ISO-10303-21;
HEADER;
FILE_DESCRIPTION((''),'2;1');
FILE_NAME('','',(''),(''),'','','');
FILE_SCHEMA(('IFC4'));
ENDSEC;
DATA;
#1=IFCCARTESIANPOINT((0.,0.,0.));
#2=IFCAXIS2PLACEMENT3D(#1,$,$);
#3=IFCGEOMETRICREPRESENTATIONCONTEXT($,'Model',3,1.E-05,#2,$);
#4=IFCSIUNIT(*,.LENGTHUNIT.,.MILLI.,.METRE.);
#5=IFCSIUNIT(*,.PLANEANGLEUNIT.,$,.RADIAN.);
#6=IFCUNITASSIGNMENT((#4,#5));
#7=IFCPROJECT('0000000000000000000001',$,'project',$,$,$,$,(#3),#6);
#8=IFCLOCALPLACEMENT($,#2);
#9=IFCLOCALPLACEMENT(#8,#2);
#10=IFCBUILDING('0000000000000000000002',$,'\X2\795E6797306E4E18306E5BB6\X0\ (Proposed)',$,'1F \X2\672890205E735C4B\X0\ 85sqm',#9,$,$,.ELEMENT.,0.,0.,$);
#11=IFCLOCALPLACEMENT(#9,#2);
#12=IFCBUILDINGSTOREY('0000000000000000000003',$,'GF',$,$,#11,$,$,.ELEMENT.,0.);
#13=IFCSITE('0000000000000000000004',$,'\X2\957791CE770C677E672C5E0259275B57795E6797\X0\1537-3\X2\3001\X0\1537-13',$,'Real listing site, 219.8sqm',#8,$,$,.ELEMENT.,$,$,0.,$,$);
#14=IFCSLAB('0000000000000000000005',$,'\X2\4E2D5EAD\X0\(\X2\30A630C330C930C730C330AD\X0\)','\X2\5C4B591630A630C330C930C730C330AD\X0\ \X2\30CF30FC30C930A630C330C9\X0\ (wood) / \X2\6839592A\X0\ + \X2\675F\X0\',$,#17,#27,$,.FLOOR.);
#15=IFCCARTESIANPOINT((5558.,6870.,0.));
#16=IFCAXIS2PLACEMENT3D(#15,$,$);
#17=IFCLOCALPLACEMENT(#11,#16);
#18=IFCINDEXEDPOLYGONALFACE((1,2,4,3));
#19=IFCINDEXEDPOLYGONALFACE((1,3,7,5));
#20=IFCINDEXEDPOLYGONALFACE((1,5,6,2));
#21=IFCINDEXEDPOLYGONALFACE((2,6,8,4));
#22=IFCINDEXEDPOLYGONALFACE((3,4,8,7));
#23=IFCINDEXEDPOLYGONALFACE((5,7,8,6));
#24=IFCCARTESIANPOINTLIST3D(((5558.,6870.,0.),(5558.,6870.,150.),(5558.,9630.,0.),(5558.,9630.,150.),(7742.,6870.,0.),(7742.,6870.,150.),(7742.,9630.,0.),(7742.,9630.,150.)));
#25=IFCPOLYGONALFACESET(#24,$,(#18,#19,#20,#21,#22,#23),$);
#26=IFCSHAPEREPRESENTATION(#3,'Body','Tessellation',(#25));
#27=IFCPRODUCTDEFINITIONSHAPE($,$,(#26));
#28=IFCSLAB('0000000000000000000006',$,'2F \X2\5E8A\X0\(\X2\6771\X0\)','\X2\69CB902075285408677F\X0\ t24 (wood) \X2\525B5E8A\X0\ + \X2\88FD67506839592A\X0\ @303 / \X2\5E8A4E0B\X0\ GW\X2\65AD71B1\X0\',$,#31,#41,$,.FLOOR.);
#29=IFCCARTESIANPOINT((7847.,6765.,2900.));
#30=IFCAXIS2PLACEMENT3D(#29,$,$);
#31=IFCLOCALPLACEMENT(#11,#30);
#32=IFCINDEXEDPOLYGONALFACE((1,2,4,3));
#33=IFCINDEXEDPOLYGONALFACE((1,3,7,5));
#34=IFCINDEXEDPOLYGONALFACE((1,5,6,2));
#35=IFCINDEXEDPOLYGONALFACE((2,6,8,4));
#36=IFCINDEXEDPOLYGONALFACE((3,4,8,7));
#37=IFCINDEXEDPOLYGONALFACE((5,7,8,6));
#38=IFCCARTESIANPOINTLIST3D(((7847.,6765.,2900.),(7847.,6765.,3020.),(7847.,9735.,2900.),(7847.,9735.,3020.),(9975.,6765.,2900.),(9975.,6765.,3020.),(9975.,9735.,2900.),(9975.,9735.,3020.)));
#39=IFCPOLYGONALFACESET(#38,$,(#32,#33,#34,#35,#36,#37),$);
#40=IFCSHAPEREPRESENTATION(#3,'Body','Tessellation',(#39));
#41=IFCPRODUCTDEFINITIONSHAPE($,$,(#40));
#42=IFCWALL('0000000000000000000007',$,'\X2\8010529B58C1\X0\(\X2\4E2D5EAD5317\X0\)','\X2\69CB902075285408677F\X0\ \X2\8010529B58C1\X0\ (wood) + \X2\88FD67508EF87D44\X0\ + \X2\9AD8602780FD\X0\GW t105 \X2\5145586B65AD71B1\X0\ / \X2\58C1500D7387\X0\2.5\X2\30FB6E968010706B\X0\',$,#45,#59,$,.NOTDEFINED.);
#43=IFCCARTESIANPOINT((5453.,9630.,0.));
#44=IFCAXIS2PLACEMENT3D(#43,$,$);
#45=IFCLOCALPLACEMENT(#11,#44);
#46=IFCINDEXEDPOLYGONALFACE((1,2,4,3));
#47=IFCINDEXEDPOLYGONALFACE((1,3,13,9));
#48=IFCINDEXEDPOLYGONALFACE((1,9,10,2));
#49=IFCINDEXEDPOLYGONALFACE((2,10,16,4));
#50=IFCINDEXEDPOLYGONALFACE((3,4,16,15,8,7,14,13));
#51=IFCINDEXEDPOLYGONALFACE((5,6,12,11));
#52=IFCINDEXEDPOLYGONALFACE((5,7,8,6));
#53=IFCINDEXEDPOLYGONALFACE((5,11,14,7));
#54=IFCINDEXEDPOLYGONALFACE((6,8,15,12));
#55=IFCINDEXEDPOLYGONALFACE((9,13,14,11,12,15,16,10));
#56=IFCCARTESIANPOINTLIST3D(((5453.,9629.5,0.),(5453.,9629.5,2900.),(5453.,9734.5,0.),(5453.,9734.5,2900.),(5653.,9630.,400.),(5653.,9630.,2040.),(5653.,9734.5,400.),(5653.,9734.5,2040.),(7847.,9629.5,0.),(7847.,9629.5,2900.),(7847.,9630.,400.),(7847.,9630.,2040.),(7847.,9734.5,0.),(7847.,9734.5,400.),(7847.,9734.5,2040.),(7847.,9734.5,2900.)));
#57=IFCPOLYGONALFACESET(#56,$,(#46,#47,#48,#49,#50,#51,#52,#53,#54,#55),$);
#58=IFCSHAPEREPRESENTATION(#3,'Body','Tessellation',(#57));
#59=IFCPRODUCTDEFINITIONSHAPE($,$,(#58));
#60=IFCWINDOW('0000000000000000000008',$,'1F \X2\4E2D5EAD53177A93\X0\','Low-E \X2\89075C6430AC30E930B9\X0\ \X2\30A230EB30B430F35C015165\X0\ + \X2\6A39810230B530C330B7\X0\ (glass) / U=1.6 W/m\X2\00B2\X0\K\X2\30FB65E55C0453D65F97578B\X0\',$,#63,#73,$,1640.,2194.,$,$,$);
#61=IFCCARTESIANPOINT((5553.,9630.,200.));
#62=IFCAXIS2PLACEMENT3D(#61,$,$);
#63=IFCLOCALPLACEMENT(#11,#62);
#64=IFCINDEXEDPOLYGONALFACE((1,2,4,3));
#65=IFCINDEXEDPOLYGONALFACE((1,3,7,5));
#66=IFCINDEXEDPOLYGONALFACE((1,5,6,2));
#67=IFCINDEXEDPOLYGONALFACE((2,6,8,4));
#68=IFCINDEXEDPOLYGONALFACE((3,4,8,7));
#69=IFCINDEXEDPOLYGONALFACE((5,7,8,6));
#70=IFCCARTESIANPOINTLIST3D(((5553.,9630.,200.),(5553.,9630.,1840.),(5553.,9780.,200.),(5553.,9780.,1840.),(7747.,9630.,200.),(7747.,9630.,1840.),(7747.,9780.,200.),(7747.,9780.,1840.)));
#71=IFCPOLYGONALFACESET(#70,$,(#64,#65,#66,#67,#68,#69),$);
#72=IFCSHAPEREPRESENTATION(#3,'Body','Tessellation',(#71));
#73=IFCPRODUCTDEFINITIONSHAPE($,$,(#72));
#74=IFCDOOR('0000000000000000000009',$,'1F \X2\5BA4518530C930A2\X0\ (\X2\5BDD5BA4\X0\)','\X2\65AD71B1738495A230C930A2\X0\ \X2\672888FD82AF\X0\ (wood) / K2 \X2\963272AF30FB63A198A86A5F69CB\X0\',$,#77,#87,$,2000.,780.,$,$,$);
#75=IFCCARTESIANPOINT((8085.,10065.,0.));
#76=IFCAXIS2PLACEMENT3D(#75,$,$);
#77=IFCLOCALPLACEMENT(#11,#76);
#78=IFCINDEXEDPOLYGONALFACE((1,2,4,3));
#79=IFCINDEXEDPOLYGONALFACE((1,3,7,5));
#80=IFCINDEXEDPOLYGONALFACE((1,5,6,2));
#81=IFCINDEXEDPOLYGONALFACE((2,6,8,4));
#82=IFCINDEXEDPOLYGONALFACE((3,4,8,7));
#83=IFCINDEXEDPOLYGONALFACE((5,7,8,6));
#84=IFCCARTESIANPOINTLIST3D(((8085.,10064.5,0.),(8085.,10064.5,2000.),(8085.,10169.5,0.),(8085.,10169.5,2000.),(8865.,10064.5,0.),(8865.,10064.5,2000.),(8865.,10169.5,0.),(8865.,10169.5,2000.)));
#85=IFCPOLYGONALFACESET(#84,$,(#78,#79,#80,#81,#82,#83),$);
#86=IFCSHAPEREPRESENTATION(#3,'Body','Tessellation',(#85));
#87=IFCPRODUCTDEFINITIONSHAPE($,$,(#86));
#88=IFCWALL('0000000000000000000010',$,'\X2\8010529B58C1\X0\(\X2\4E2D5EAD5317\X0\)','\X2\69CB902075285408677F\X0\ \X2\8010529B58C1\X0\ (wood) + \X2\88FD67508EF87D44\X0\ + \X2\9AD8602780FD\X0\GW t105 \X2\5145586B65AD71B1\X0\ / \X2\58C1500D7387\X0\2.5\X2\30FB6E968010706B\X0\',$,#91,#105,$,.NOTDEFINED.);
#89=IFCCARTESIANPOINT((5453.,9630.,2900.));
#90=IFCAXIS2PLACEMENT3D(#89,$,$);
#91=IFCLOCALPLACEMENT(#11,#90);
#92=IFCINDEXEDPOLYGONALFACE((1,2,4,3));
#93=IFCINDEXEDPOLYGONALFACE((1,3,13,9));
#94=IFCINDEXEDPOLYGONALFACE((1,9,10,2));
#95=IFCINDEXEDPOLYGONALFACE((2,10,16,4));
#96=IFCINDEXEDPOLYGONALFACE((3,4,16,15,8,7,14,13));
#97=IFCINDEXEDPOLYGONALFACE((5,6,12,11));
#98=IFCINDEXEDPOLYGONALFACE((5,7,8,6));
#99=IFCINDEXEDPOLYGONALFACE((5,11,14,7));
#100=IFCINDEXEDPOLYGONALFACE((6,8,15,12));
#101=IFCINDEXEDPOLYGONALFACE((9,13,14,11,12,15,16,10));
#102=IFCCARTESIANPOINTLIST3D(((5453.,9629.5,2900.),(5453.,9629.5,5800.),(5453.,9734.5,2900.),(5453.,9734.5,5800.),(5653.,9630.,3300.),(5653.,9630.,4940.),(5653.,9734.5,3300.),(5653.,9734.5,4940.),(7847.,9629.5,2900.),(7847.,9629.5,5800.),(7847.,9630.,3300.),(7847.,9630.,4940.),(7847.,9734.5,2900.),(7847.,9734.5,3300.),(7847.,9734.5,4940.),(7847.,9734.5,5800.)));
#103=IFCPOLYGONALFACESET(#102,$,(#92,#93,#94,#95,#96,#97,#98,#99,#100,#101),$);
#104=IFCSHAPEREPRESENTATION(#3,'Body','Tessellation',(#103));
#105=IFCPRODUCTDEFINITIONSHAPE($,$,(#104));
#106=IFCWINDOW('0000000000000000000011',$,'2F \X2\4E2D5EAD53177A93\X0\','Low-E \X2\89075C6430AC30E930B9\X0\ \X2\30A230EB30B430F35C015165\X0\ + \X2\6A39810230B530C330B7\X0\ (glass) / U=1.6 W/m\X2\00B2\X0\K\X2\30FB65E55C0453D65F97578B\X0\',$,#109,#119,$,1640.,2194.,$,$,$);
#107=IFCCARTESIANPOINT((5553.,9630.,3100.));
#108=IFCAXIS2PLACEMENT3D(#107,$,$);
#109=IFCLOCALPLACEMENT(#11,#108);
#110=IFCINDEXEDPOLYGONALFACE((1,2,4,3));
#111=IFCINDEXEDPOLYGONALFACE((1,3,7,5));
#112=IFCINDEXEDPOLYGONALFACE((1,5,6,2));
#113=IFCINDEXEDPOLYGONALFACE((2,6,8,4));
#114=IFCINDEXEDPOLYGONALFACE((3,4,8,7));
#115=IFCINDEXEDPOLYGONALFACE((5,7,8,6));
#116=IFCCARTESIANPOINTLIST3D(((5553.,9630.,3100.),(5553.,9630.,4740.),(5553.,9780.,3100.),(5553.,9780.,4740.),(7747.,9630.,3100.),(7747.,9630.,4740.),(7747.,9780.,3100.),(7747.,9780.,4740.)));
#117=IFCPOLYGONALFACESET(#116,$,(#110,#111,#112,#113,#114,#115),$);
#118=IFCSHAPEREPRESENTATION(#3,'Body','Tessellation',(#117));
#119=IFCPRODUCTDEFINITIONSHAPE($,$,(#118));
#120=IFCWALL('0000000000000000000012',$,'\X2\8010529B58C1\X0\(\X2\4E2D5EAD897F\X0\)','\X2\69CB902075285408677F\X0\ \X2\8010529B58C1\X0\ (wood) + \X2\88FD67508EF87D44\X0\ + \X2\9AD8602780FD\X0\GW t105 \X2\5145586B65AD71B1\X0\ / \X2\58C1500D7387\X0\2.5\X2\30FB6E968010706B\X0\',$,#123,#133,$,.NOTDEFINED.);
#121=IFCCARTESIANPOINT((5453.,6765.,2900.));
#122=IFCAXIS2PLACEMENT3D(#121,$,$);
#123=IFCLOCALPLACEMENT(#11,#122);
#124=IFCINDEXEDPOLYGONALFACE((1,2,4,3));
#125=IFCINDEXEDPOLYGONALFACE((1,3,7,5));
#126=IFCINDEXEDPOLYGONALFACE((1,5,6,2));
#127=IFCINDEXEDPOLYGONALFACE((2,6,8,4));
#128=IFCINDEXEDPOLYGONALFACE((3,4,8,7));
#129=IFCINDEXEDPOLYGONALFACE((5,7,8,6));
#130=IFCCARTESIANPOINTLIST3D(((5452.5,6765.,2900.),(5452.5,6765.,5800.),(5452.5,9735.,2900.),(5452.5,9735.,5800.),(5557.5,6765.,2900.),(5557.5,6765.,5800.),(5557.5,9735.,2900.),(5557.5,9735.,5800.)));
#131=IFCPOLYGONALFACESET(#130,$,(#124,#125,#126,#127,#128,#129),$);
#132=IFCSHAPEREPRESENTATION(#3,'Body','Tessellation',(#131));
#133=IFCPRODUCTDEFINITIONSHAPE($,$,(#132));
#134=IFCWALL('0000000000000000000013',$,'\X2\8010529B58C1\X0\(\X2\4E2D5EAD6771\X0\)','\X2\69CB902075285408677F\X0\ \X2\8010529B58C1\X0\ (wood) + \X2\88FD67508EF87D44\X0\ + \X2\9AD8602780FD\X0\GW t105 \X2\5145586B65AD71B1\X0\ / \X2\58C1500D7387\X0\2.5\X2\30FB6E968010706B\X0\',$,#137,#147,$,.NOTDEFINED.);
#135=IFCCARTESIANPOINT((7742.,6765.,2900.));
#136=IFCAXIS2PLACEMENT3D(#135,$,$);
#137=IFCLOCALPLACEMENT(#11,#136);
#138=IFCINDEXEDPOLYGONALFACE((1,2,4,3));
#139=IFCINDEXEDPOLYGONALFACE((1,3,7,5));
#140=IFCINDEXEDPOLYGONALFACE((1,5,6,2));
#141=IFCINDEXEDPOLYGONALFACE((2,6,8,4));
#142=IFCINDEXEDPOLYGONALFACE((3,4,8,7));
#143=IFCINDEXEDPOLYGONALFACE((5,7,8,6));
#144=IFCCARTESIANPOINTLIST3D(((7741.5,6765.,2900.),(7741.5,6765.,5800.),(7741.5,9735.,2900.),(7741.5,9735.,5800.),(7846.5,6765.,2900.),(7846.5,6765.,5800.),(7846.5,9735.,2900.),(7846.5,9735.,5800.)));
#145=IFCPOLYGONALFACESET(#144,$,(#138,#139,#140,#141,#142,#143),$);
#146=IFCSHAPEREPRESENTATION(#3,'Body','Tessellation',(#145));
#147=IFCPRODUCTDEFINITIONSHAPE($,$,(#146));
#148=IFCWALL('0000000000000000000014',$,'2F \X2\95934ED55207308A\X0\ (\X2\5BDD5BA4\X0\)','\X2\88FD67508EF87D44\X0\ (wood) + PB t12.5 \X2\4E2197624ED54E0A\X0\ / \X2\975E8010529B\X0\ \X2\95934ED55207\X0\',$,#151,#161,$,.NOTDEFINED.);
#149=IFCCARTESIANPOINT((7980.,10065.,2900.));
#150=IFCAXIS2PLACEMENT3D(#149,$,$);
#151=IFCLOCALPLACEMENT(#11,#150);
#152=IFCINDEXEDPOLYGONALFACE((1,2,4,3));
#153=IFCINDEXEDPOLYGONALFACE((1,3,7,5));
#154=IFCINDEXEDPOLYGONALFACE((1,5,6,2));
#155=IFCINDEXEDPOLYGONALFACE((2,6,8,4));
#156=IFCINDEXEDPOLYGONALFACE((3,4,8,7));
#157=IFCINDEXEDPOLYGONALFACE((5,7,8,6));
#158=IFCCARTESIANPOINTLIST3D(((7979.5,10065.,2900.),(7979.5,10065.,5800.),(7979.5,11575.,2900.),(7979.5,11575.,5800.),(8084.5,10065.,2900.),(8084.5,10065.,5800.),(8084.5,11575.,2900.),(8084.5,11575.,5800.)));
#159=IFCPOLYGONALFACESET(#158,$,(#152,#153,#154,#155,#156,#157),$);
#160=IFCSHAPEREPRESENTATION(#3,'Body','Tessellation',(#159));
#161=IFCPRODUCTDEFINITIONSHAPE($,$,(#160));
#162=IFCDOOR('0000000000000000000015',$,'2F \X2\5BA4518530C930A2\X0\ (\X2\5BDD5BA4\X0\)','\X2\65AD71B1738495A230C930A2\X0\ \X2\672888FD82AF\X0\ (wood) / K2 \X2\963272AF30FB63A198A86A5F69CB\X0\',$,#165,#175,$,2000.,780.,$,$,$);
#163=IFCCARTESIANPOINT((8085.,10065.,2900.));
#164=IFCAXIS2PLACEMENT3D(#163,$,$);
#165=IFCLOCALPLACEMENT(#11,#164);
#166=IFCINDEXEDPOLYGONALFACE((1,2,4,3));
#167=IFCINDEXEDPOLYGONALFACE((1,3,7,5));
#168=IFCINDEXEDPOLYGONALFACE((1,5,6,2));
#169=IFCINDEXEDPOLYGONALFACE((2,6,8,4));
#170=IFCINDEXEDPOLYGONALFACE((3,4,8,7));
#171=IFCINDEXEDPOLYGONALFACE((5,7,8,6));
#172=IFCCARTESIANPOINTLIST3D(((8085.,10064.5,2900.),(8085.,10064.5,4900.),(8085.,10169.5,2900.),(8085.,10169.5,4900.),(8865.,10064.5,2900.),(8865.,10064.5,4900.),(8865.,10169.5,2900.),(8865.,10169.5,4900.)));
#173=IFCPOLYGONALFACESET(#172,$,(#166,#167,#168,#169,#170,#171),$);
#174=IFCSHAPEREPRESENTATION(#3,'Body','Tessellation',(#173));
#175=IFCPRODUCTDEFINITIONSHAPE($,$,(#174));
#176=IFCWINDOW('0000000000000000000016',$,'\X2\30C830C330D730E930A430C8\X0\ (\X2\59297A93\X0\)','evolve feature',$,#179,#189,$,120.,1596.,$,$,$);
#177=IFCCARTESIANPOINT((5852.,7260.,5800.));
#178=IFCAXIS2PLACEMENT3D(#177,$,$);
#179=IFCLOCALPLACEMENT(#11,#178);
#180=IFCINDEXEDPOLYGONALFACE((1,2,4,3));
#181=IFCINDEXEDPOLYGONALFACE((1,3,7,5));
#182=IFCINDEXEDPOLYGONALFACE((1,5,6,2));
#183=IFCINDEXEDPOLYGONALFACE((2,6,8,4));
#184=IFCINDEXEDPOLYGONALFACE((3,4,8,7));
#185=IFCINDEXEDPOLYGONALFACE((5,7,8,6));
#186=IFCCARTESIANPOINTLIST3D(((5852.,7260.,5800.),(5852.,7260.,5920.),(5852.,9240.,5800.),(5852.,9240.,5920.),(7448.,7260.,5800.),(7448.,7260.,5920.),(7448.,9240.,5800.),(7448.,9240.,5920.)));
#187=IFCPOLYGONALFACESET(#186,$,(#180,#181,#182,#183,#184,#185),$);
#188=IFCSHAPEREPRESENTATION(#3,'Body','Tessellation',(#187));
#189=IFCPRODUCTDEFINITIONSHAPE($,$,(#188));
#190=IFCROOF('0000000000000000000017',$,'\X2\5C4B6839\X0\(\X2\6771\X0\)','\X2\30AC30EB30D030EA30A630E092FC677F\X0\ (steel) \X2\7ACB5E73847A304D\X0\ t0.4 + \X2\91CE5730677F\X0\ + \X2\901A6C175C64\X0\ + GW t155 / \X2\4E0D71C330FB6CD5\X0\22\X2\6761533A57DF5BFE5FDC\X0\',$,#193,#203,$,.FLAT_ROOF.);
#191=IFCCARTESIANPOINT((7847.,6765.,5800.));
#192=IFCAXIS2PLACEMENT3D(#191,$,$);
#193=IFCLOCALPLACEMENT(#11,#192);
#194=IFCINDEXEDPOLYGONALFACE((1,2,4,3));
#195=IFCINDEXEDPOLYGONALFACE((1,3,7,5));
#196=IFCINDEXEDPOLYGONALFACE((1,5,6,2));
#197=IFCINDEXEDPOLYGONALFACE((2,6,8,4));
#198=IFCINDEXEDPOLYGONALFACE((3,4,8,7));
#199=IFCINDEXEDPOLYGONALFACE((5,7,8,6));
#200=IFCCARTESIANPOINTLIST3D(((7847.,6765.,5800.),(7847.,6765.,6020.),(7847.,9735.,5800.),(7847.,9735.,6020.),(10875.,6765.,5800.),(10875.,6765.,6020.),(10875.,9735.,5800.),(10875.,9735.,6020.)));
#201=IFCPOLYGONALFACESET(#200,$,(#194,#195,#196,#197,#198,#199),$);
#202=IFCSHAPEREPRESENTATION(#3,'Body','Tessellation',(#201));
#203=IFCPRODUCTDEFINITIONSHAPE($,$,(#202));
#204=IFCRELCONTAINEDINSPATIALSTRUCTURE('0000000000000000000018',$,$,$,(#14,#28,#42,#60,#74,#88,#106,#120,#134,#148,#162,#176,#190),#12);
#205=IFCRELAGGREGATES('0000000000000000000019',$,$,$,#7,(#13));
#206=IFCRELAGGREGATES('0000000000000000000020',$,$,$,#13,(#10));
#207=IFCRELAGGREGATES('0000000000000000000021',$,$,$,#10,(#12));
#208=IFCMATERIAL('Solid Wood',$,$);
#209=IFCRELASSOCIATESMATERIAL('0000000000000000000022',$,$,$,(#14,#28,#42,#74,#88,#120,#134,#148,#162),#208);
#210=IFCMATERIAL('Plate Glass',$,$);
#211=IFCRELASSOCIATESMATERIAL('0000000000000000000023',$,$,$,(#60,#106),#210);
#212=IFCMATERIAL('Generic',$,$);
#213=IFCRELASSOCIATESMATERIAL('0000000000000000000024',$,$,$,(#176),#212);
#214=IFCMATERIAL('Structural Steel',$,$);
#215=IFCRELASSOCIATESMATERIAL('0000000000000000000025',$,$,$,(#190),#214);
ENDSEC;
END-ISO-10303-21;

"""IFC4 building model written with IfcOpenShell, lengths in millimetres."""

from ifc_helpers import new_model, si_unit, frame, frame_2d, origin, place, context, project, spatial, rectangle, extrude, material, element, fill, save


model = new_model("IFC4")

# Units and contexts
model_context = context("Model", 3, precision=1e-05, world=origin())
ifc_project = project(units=[si_unit("LENGTHUNIT", "METRE", prefix="MILLI"), si_unit("PLANEANGLEUNIT", "RADIAN")], contexts=[model_context])

# Site, building, storey
site_placement = place(None, origin())
site = spatial("IfcSite", under=ifc_project, at=site_placement, Name="長野県松本市大字神林1537-3、1537-13", ObjectType="Real listing site, 219.8sqm", CompositionType="ELEMENT", RefElevation=0.0)
building_placement = place(site_placement, origin())
building = spatial("IfcBuilding", under=site, at=building_placement, Name="神林の丘の家 (Proposed)", ObjectType="1F 木造平屋 85sqm", CompositionType="ELEMENT", ElevationOfRefHeight=0.0, ElevationOfTerrain=0.0)
storey_placement = place(building_placement, origin())
storey = spatial("IfcBuildingStorey", under=building, at=storey_placement, Name="GF", CompositionType="ELEMENT", Elevation=0.0)

# Slabs
ifc_material_1 = material(Name="Solid Wood")
slab_1_placement = place(storey_placement, frame((5558.0, 6870.0, 0.0)))
element("IfcSlab", 1, at=slab_1_placement, inside=storey, material=ifc_material_1, Name="中庭(ウッドデッキ)", Description="屋外ウッドデッキ ハードウッド (wood) / 根太 + 束", PredefinedType="FLOOR", context=model_context, shape_type="SweptSolid", body=[
    extrude(rectangle(XDim=2184.0, YDim=2760.0, at=frame_2d((1092.0, 1380.0))), frame((5558.0, 6870.0, 0.0)), (0.0, 0.0, 1.0), 150.0),
])
slab_2_placement = place(storey_placement, frame((7847.0, 6765.0, 2900.0)))
element("IfcSlab", 2, at=slab_2_placement, inside=storey, material=ifc_material_1, Name="2F 床(東)", Description="構造用合板 t24 (wood) 剛床 + 製材根太 @303 / 床下 GW断熱", PredefinedType="FLOOR", context=model_context, shape_type="SweptSolid", body=[
    extrude(rectangle(XDim=2128.0, YDim=2970.0, at=frame_2d((1064.0, 1485.0))), frame((7847.0, 6765.0, 2900.0)), (0.0, 0.0, 1.0), 120.0),
])

# Wall, opening, window
wall_1_placement = place(storey_placement, frame((5453.0, 9630.0, 0.0)))
wall_1 = element("IfcWall", 3, at=wall_1_placement, inside=storey, material=ifc_material_1, Name="耐力壁(中庭北)", Description="構造用合板 耐力壁 (wood) + 製材軸組 + 高性能GW t105 充填断熱 / 壁倍率2.5・準耐火", PredefinedType="NOTDEFINED", context=model_context, shape_type="SweptSolid", body=[
    extrude(rectangle(XDim=2394.0, YDim=105.0, at=frame_2d((1197.0, 52.0))), frame((5453.0, 9630.0, 0.0)), (0.0, 0.0, 1.0), 2900.0),
])
opening_1_placement = place(storey_placement, frame((5553.0, 9630.0, 200.0)))
opening_1 = element("IfcOpeningElement", 4, at=opening_1_placement, cuts=wall_1, PredefinedType="NOTDEFINED", context=model_context, shape_type="SweptSolid", body=[
    extrude(rectangle(XDim=2194.0, YDim=150.0, at=frame_2d((1097.0, 75.0))), frame((5553.0, 9630.0, 200.0)), (0.0, 0.0, 1.0), 1640.0),
])
ifc_material_2 = material(Name="Plate Glass")
window_1_placement = place(storey_placement, frame((5553.0, 9630.0, 200.0)))
window_1 = element("IfcWindow", 5, at=window_1_placement, inside=storey, material=ifc_material_2, Name="1F 中庭北窓", Description="Low-E 複層ガラス アルゴン封入 + 樹脂サッシ (glass) / U=1.6 W/m²K・日射取得型", OverallHeight=1640.0, OverallWidth=2194.0, context=model_context, shape_type="SweptSolid", body=[
    extrude(rectangle(XDim=2194.0, YDim=150.0, at=frame_2d((1097.0, 75.0))), frame((5553.0, 9630.0, 200.0)), (0.0, 0.0, 1.0), 1640.0),
])
fill(opening_1, window_1)

# Door
door_1_placement = place(storey_placement, frame((8085.0, 10065.0, 0.0)))
element("IfcDoor", 6, at=door_1_placement, inside=storey, material=ifc_material_1, Name="1F 室内ドア (寝室)", Description="断熱玄関ドア 木製芯 (wood) / K2 防犯・採風機構", OverallHeight=2000.0, OverallWidth=780.0, context=model_context, shape_type="SweptSolid", body=[
    extrude(rectangle(XDim=780.0, YDim=105.0, at=frame_2d((390.0, 52.0))), frame((8085.0, 10065.0, 0.0)), (0.0, 0.0, 1.0), 2000.0),
])

# Wall, opening, window
wall_2_placement = place(storey_placement, frame((5453.0, 9630.0, 2900.0)))
wall_2 = element("IfcWall", 7, at=wall_2_placement, inside=storey, material=ifc_material_1, Name="耐力壁(中庭北)", Description="構造用合板 耐力壁 (wood) + 製材軸組 + 高性能GW t105 充填断熱 / 壁倍率2.5・準耐火", PredefinedType="NOTDEFINED", context=model_context, shape_type="SweptSolid", body=[
    extrude(rectangle(XDim=2394.0, YDim=105.0, at=frame_2d((1197.0, 52.0))), frame((5453.0, 9630.0, 2900.0)), (0.0, 0.0, 1.0), 2900.0),
])
opening_2_placement = place(storey_placement, frame((5553.0, 9630.0, 3100.0)))
opening_2 = element("IfcOpeningElement", 8, at=opening_2_placement, cuts=wall_2, PredefinedType="NOTDEFINED", context=model_context, shape_type="SweptSolid", body=[
    extrude(rectangle(XDim=2194.0, YDim=150.0, at=frame_2d((1097.0, 75.0))), frame((5553.0, 9630.0, 3100.0)), (0.0, 0.0, 1.0), 1640.0),
])
window_2_placement = place(storey_placement, frame((5553.0, 9630.0, 3100.0)))
window_2 = element("IfcWindow", 9, at=window_2_placement, inside=storey, material=ifc_material_2, Name="2F 中庭北窓", Description="Low-E 複層ガラス アルゴン封入 + 樹脂サッシ (glass) / U=1.6 W/m²K・日射取得型", OverallHeight=1640.0, OverallWidth=2194.0, context=model_context, shape_type="SweptSolid", body=[
    extrude(rectangle(XDim=2194.0, YDim=150.0, at=frame_2d((1097.0, 75.0))), frame((5553.0, 9630.0, 3100.0)), (0.0, 0.0, 1.0), 1640.0),
])
fill(opening_2, window_2)

# Walls
wall_3_placement = place(storey_placement, frame((5453.0, 6765.0, 2900.0)))
element("IfcWall", 10, at=wall_3_placement, inside=storey, material=ifc_material_1, Name="耐力壁(中庭西)", Description="構造用合板 耐力壁 (wood) + 製材軸組 + 高性能GW t105 充填断熱 / 壁倍率2.5・準耐火", PredefinedType="NOTDEFINED", context=model_context, shape_type="SweptSolid", body=[
    extrude(rectangle(XDim=105.0, YDim=2970.0, at=frame_2d((52.0, 1485.0))), frame((5453.0, 6765.0, 2900.0)), (0.0, 0.0, 1.0), 2900.0),
])
wall_4_placement = place(storey_placement, frame((7742.0, 6765.0, 2900.0)))
element("IfcWall", 11, at=wall_4_placement, inside=storey, material=ifc_material_1, Name="耐力壁(中庭東)", Description="構造用合板 耐力壁 (wood) + 製材軸組 + 高性能GW t105 充填断熱 / 壁倍率2.5・準耐火", PredefinedType="NOTDEFINED", context=model_context, shape_type="SweptSolid", body=[
    extrude(rectangle(XDim=105.0, YDim=2970.0, at=frame_2d((52.0, 1485.0))), frame((7742.0, 6765.0, 2900.0)), (0.0, 0.0, 1.0), 2900.0),
])
wall_5_placement = place(storey_placement, frame((7980.0, 10065.0, 2900.0)))
element("IfcWall", 12, at=wall_5_placement, inside=storey, material=ifc_material_1, Name="2F 間仕切り (寝室)", Description="製材軸組 (wood) + PB t12.5 両面仕上 / 非耐力 間仕切", PredefinedType="NOTDEFINED", context=model_context, shape_type="SweptSolid", body=[
    extrude(rectangle(XDim=105.0, YDim=1510.0, at=frame_2d((52.0, 755.0))), frame((7980.0, 10065.0, 2900.0)), (0.0, 0.0, 1.0), 2900.0),
])

# Door
door_2_placement = place(storey_placement, frame((8085.0, 10065.0, 2900.0)))
element("IfcDoor", 13, at=door_2_placement, inside=storey, material=ifc_material_1, Name="2F 室内ドア (寝室)", Description="断熱玄関ドア 木製芯 (wood) / K2 防犯・採風機構", OverallHeight=2000.0, OverallWidth=780.0, context=model_context, shape_type="SweptSolid", body=[
    extrude(rectangle(XDim=780.0, YDim=105.0, at=frame_2d((390.0, 52.0))), frame((8085.0, 10065.0, 2900.0)), (0.0, 0.0, 1.0), 2000.0),
])

# Window
ifc_material_3 = material(Name="Generic")
window_3_placement = place(storey_placement, frame((5852.0, 7260.0, 5800.0)))
element("IfcWindow", 14, at=window_3_placement, inside=storey, material=ifc_material_3, Name="トップライト (天窓)", Description="evolve feature", OverallHeight=120.0, OverallWidth=1596.0, context=model_context, shape_type="SweptSolid", body=[
    extrude(rectangle(XDim=1596.0, YDim=1980.0, at=frame_2d((798.0, 990.0))), frame((5852.0, 7260.0, 5800.0)), (0.0, 0.0, 1.0), 120.0),
])

# Roof
ifc_material_4 = material(Name="Structural Steel")
roof_placement = place(storey_placement, frame((7847.0, 6765.0, 5800.0)))
element("IfcRoof", 15, at=roof_placement, inside=storey, material=ifc_material_4, Name="屋根(東)", Description="ガルバリウム鋼板 (steel) 立平葺き t0.4 + 野地板 + 通気層 + GW t155 / 不燃・法22条区域対応", PredefinedType="FLAT_ROOF", context=model_context, shape_type="SweptSolid", body=[
    extrude(rectangle(XDim=3028.0, YDim=2970.0, at=frame_2d((1514.0, 1485.0))), frame((7847.0, 6765.0, 5800.0)), (0.0, 0.0, 1.0), 220.0),
])

save(model, "model.ifc")
